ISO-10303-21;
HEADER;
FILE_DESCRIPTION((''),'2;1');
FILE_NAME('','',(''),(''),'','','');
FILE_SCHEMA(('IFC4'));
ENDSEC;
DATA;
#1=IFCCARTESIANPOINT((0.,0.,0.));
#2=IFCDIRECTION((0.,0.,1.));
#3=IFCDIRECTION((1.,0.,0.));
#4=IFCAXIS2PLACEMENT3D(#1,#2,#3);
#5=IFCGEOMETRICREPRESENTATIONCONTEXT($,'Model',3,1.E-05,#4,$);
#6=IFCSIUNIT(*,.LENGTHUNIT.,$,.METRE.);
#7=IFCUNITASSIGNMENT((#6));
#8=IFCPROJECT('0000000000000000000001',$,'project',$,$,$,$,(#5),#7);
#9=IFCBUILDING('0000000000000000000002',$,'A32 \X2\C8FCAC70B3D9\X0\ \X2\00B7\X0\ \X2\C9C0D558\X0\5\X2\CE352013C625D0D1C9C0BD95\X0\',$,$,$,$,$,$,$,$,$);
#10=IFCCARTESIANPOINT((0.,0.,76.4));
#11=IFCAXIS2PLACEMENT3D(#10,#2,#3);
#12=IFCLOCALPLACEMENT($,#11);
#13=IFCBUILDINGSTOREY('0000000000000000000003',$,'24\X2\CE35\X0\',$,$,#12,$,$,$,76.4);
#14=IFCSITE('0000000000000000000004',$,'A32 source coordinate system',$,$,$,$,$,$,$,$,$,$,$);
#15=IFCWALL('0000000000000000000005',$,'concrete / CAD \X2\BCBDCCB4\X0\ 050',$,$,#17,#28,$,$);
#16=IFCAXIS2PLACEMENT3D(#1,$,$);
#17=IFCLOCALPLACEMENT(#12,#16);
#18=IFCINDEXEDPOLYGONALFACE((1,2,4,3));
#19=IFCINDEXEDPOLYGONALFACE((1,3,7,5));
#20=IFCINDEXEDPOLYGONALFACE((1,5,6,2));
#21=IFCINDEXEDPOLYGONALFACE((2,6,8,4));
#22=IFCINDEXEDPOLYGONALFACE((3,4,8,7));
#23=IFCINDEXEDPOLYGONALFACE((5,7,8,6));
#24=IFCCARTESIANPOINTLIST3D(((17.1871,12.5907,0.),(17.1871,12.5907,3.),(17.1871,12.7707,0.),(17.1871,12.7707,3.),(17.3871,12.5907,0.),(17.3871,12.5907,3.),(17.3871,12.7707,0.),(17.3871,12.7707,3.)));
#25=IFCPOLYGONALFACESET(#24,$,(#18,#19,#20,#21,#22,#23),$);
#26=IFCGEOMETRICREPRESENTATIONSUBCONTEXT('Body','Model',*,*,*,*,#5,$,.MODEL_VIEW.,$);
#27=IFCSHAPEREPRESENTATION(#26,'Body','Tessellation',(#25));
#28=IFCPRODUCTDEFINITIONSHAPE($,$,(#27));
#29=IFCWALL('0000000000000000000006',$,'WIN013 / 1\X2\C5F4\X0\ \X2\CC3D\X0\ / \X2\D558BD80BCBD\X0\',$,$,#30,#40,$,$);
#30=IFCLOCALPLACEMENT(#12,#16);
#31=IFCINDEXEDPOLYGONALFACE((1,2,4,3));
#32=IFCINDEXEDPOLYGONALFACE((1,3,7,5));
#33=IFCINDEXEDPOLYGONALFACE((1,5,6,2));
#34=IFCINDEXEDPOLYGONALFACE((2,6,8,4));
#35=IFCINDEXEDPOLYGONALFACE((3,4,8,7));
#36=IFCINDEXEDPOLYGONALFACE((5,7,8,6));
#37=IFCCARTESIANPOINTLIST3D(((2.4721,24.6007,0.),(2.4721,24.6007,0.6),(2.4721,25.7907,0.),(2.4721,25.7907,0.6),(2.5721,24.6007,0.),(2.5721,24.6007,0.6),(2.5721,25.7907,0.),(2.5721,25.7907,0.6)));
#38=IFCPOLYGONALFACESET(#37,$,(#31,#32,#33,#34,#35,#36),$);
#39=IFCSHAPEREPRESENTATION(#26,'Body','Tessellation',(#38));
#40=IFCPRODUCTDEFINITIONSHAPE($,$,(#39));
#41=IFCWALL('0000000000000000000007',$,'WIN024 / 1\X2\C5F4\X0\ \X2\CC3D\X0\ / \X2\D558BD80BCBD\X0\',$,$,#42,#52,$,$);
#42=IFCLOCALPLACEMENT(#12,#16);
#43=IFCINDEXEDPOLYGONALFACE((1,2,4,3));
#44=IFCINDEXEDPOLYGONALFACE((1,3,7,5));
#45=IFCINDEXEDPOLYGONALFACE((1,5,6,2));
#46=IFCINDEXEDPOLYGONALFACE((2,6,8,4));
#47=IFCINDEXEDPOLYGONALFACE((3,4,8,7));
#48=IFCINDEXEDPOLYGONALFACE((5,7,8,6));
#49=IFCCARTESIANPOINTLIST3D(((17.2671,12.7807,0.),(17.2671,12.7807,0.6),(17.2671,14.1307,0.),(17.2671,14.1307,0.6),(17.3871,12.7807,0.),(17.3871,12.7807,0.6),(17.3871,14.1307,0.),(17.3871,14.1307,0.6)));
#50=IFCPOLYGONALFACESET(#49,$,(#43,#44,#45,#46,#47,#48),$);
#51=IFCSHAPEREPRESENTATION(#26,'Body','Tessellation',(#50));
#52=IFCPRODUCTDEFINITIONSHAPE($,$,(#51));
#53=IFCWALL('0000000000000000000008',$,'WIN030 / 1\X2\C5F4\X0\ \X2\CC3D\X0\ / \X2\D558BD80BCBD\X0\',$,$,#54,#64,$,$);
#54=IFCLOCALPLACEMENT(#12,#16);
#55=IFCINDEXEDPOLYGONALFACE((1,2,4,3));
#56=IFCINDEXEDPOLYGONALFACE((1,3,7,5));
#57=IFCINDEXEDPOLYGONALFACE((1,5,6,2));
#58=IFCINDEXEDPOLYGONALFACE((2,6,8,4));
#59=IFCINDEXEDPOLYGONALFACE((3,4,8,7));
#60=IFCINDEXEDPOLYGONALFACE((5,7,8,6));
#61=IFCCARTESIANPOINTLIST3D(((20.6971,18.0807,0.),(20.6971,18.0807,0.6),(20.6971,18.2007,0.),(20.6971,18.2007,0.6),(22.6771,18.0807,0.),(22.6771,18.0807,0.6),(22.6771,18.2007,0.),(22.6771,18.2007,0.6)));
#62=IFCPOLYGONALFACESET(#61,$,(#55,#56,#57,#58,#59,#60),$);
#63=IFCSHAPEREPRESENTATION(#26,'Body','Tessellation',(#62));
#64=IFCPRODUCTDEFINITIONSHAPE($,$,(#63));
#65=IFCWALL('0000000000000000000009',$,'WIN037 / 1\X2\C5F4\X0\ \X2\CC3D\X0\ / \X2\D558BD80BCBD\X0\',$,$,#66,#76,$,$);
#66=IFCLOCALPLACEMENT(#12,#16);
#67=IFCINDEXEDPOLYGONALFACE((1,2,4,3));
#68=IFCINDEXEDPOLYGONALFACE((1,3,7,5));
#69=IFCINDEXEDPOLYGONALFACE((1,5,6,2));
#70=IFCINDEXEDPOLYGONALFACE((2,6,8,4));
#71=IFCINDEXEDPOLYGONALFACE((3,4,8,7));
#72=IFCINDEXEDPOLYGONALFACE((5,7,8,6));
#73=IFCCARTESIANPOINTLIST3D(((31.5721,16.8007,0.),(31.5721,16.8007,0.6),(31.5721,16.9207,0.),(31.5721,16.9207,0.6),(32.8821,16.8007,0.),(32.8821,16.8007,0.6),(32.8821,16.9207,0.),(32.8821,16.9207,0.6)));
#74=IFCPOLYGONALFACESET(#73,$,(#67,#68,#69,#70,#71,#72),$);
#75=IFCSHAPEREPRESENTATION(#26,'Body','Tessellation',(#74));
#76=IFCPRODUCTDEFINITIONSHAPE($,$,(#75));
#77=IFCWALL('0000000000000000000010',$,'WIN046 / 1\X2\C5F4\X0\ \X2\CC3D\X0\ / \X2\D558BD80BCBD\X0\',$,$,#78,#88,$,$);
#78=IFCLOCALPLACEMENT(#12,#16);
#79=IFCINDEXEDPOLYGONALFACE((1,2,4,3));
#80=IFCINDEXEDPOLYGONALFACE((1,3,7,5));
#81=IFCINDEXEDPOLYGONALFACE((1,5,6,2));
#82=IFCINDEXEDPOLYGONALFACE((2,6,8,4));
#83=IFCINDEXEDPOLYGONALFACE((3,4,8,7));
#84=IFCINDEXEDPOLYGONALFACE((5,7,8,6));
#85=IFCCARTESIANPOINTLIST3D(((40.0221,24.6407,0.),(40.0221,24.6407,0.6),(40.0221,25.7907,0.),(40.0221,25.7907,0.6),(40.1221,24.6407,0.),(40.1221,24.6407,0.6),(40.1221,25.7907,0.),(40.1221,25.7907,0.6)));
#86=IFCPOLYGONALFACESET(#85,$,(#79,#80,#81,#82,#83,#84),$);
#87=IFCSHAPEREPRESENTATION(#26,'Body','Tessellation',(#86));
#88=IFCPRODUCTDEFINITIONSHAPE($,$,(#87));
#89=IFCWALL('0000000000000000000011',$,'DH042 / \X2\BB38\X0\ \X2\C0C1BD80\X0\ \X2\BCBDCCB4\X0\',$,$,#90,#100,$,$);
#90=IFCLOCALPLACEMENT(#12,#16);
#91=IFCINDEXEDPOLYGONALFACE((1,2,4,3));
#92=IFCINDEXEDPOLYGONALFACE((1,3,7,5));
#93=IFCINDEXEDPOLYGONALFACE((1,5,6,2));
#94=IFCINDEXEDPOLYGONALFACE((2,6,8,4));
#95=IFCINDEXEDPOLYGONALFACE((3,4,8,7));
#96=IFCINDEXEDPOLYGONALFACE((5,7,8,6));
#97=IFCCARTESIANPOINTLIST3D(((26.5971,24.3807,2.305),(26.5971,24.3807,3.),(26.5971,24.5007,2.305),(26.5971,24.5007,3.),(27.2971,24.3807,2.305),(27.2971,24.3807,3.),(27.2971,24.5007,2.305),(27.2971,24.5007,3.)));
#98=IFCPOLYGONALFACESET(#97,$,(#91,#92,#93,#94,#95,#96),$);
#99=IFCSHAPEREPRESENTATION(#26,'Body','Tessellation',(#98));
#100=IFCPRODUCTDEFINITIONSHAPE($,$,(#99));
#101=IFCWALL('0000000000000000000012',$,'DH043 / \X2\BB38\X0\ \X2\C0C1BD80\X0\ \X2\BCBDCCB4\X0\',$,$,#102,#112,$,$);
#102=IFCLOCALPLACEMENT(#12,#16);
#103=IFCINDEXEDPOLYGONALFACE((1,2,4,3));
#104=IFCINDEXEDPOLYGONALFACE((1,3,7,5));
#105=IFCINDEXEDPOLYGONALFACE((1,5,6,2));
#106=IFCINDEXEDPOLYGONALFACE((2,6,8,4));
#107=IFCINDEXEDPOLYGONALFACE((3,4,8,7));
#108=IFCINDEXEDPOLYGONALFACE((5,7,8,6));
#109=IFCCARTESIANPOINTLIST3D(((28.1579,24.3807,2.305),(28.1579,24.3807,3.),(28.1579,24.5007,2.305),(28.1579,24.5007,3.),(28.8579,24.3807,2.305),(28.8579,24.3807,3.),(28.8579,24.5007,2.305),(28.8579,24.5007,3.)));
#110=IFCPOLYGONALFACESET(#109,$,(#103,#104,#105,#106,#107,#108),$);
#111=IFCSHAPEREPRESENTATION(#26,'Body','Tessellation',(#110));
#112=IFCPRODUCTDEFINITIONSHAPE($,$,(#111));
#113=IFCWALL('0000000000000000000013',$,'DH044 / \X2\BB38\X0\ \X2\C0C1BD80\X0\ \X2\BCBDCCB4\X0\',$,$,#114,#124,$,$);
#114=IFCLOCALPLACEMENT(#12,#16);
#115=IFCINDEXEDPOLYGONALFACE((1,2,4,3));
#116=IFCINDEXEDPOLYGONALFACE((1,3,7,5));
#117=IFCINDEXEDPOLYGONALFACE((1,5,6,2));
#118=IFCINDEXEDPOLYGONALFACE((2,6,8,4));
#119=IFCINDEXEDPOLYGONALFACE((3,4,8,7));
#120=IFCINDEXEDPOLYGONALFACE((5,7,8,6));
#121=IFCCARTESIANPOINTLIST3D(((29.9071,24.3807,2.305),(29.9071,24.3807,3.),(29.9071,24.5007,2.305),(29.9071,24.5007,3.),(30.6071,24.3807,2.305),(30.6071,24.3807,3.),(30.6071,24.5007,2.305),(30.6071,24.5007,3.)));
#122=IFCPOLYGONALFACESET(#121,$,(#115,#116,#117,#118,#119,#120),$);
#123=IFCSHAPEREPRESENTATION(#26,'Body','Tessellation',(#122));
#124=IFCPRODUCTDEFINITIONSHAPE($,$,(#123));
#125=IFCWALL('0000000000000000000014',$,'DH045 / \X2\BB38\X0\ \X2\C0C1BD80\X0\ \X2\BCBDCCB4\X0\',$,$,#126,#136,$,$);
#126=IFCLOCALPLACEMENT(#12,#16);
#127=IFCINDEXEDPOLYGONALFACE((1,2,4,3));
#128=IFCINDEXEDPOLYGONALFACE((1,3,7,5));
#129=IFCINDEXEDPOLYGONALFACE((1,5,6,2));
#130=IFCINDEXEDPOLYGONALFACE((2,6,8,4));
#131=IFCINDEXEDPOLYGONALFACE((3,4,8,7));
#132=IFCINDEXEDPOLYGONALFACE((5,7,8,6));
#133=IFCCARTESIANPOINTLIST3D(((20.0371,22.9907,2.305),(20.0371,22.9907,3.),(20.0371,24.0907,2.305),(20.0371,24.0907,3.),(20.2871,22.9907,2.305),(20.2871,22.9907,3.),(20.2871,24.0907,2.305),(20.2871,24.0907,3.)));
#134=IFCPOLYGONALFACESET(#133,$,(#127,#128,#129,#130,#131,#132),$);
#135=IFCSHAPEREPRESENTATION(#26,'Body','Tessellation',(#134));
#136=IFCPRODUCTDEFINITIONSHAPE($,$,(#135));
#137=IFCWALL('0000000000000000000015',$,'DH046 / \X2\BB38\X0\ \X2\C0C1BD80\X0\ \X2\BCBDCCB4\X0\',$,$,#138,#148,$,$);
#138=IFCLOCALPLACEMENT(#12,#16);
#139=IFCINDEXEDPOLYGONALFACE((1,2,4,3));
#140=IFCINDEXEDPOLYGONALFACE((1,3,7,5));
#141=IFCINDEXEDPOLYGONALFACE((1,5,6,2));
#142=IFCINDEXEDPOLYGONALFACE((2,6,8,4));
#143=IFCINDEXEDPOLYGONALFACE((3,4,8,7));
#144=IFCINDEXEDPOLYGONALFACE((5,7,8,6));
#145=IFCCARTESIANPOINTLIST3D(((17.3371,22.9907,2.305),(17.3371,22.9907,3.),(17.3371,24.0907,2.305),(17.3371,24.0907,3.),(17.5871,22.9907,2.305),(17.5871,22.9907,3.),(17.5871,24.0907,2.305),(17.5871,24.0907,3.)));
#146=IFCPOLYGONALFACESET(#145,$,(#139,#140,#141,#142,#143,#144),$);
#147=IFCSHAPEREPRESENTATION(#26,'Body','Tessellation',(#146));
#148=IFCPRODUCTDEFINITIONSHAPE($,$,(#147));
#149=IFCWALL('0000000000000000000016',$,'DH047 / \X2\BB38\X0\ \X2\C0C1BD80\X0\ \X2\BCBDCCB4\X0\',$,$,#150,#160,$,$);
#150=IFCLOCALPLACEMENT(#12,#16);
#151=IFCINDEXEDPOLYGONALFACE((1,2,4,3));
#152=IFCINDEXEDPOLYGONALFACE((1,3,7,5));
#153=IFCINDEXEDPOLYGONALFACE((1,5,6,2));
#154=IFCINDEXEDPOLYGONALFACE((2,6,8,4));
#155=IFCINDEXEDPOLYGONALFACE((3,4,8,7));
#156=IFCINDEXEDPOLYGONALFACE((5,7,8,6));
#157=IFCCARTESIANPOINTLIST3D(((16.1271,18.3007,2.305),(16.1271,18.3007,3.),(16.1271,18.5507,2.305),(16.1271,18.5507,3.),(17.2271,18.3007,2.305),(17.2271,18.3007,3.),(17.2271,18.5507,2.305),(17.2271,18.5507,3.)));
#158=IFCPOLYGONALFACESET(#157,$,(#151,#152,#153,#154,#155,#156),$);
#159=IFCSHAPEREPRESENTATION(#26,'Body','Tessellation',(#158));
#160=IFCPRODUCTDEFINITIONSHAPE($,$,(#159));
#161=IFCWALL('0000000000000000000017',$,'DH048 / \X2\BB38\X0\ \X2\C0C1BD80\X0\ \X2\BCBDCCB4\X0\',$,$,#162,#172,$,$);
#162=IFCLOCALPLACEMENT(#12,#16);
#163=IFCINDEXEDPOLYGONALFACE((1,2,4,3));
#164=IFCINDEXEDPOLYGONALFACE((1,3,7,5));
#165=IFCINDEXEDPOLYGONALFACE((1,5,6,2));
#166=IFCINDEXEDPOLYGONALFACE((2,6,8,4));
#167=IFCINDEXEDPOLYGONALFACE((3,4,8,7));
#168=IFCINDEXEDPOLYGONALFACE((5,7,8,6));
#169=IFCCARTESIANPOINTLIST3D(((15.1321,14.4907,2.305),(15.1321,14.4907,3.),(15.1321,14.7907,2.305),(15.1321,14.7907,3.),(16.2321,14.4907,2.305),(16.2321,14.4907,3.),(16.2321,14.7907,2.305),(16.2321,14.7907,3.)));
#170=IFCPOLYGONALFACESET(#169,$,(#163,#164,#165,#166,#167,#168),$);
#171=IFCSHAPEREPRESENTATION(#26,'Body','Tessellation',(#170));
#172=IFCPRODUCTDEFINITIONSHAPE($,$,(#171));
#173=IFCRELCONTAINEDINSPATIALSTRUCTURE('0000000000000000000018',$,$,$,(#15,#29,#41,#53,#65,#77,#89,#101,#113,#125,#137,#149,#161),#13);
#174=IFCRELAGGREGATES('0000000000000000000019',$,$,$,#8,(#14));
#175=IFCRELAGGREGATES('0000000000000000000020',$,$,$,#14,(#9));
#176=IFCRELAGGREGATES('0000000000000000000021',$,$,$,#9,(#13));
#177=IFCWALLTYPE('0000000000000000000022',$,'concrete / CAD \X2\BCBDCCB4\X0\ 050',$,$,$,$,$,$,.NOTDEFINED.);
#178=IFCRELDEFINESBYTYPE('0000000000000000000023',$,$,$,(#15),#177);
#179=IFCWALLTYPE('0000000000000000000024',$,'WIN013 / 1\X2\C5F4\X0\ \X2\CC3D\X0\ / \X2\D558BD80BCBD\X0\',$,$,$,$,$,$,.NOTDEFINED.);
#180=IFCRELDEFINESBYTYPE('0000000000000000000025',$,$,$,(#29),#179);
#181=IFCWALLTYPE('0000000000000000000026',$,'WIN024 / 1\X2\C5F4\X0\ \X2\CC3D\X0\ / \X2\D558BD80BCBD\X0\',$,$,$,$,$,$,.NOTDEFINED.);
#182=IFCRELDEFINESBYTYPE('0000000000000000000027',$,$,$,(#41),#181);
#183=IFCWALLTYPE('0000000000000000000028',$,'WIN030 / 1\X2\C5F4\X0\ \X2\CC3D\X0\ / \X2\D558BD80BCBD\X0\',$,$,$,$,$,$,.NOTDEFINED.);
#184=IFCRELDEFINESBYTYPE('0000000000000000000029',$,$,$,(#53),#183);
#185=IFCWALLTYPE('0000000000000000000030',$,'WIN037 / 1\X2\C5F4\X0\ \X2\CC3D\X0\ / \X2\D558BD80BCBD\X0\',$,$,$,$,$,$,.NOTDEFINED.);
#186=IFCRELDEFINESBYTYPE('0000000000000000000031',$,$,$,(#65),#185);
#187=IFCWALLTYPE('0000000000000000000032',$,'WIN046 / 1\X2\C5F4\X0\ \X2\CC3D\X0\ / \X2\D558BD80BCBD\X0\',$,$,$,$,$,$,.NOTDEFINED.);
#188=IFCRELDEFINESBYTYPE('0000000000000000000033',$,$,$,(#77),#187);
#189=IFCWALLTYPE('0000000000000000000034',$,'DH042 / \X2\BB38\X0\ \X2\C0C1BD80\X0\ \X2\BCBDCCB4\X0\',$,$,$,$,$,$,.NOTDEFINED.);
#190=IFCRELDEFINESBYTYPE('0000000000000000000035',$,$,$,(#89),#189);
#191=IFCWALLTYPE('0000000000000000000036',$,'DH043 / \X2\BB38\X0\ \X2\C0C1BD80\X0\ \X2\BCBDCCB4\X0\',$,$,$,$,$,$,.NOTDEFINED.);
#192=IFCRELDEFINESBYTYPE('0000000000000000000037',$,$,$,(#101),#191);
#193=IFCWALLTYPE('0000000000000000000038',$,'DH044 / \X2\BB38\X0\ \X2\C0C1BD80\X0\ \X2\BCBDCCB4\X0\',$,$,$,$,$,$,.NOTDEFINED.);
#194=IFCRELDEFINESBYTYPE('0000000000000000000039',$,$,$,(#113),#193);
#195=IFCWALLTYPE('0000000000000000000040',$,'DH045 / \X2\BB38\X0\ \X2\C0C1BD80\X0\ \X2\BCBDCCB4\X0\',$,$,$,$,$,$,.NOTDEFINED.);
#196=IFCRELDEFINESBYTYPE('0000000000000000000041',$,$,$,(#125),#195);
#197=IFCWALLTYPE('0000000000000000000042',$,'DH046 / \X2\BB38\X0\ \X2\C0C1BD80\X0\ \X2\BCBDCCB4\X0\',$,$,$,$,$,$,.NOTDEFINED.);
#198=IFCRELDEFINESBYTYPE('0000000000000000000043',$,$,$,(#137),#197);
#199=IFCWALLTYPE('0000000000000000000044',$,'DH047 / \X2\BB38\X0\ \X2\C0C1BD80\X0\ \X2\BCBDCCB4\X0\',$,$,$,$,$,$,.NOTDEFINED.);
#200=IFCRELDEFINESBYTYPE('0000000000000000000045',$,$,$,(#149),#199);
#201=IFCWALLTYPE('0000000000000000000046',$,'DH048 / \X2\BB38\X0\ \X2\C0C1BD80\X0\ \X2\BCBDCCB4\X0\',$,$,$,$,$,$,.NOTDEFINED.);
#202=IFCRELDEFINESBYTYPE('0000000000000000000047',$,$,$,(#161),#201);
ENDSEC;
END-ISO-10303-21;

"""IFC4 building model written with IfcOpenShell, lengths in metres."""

from ifc_helpers import new_model, si_unit, frame, origin, origin_with_axes, place, context, subcontext, project, spatial, polyline, outline, extrude, source, transform, mapped, type_object, type_shapes, element, save


model = new_model("IFC4")

# Units and contexts
model_context = context("Model", 3, precision=1e-05, world=origin_with_axes())
body_context = subcontext(model_context, "Body", "Model", "MODEL_VIEW")
ifc_project = project(units=[si_unit("LENGTHUNIT", "METRE")], contexts=[model_context])

# Site, building, storey
site = spatial("IfcSite", under=ifc_project, Name="A32 source coordinate system")
building = spatial("IfcBuilding", under=site, Name="A32 주거동 · 지하5층–옥탑지붕")
storey_placement = place(None, frame((0.0, 0.0, 76.4), z_axis=(0.0, 0.0, 1.0), x_axis=(1.0, 0.0, 0.0)))
storey = spatial("IfcBuildingStorey", under=building, at=storey_placement, Name="24층", Elevation=76.4)

# Walls
wall_type_1 = type_object("IfcWallType", Name="concrete / CAD 벽체 050", PredefinedType="NOTDEFINED")
shared_shape_1 = source(origin(), body_context, "Body", "SweptSolid", [
    extrude(outline(polyline([(17.1871, 12.5907), (17.1871, 12.7707), (17.3871, 12.7707), (17.3871, 12.5907), (17.1871, 12.5907)])), origin(), (0.0, 0.0, 1.0), 3.0),
])
type_shapes(wall_type_1, [shared_shape_1])
wall_1_placement = place(storey_placement, origin_with_axes())
element("IfcWall", 1, at=wall_1_placement, inside=storey, type_object=wall_type_1, Name="concrete / CAD 벽체 050", context=body_context, shape_type="MappedRepresentation", body=[
    mapped(shared_shape_1, transform((0.0, 0.0, 0.0), scale=1.0)),
])
wall_type_2 = type_object("IfcWallType", Name="WIN013 / 1열 창 / 하부벽", PredefinedType="NOTDEFINED")
shared_shape_2 = source(origin(), body_context, "Body", "SweptSolid", [
    extrude(outline(polyline([(2.5721, 25.7907), (2.5721, 24.6007), (2.4721, 24.6007), (2.4721, 25.7907), (2.5721, 25.7907)])), origin(), (0.0, 0.0, 1.0), 0.6),
])
type_shapes(wall_type_2, [shared_shape_2])
wall_2_placement = place(storey_placement, origin_with_axes())
element("IfcWall", 2, at=wall_2_placement, inside=storey, type_object=wall_type_2, Name="WIN013 / 1열 창 / 하부벽", context=body_context, shape_type="MappedRepresentation", body=[
    mapped(shared_shape_2, transform((0.0, 0.0, 0.0), scale=1.0)),
])
wall_type_3 = type_object("IfcWallType", Name="WIN024 / 1열 창 / 하부벽", PredefinedType="NOTDEFINED")
shared_shape_3 = source(origin(), body_context, "Body", "SweptSolid", [
    extrude(outline(polyline([(17.3871, 14.1307), (17.3871, 12.7807), (17.2671, 12.7807), (17.2671, 14.1307), (17.3871, 14.1307)])), origin(), (0.0, 0.0, 1.0), 0.6),
])
type_shapes(wall_type_3, [shared_shape_3])
wall_3_placement = place(storey_placement, origin_with_axes())
element("IfcWall", 3, at=wall_3_placement, inside=storey, type_object=wall_type_3, Name="WIN024 / 1열 창 / 하부벽", context=body_context, shape_type="MappedRepresentation", body=[
    mapped(shared_shape_3, transform((0.0, 0.0, 0.0), scale=1.0)),
])
wall_type_4 = type_object("IfcWallType", Name="WIN030 / 1열 창 / 하부벽", PredefinedType="NOTDEFINED")
shared_shape_4 = source(origin(), body_context, "Body", "SweptSolid", [
    extrude(outline(polyline([(22.6771, 18.2007), (22.6771, 18.0807), (20.6971, 18.0807), (20.6971, 18.2007), (22.6771, 18.2007)])), origin(), (0.0, 0.0, 1.0), 0.6),
])
type_shapes(wall_type_4, [shared_shape_4])
wall_4_placement = place(storey_placement, origin_with_axes())
element("IfcWall", 4, at=wall_4_placement, inside=storey, type_object=wall_type_4, Name="WIN030 / 1열 창 / 하부벽", context=body_context, shape_type="MappedRepresentation", body=[
    mapped(shared_shape_4, transform((0.0, 0.0, 0.0), scale=1.0)),
])
wall_type_5 = type_object("IfcWallType", Name="WIN037 / 1열 창 / 하부벽", PredefinedType="NOTDEFINED")
shared_shape_5 = source(origin(), body_context, "Body", "SweptSolid", [
    extrude(outline(polyline([(32.8821, 16.9207), (32.8821, 16.8007), (31.5721, 16.8007), (31.5721, 16.9207), (32.8821, 16.9207)])), origin(), (0.0, 0.0, 1.0), 0.6),
])
type_shapes(wall_type_5, [shared_shape_5])
wall_5_placement = place(storey_placement, origin_with_axes())
element("IfcWall", 5, at=wall_5_placement, inside=storey, type_object=wall_type_5, Name="WIN037 / 1열 창 / 하부벽", context=body_context, shape_type="MappedRepresentation", body=[
    mapped(shared_shape_5, transform((0.0, 0.0, 0.0), scale=1.0)),
])
wall_type_6 = type_object("IfcWallType", Name="WIN046 / 1열 창 / 하부벽", PredefinedType="NOTDEFINED")
shared_shape_6 = source(origin(), body_context, "Body", "SweptSolid", [
    extrude(outline(polyline([(40.1221, 25.7907), (40.1221, 24.6407), (40.0221, 24.6407), (40.0221, 25.7907), (40.1221, 25.7907)])), origin(), (0.0, 0.0, 1.0), 0.6),
])
type_shapes(wall_type_6, [shared_shape_6])
wall_6_placement = place(storey_placement, origin_with_axes())
element("IfcWall", 6, at=wall_6_placement, inside=storey, type_object=wall_type_6, Name="WIN046 / 1열 창 / 하부벽", context=body_context, shape_type="MappedRepresentation", body=[
    mapped(shared_shape_6, transform((0.0, 0.0, 0.0), scale=1.0)),
])
wall_type_7 = type_object("IfcWallType", Name="DH042 / 문 상부 벽체", PredefinedType="NOTDEFINED")
shared_shape_7 = source(origin(), body_context, "Body", "SweptSolid", [
    extrude(outline(polyline([(27.2971, 24.3807), (26.5971, 24.3807), (26.5971, 24.5007), (27.2971, 24.5007), (27.2971, 24.3807)])), frame((0.0, 0.0, 2.305)), (0.0, 0.0, 1.0), 0.695),
])
type_shapes(wall_type_7, [shared_shape_7])
wall_7_placement = place(storey_placement, origin_with_axes())
element("IfcWall", 7, at=wall_7_placement, inside=storey, type_object=wall_type_7, Name="DH042 / 문 상부 벽체", context=body_context, shape_type="MappedRepresentation", body=[
    mapped(shared_shape_7, transform((0.0, 0.0, 0.0), scale=1.0)),
])
wall_type_8 = type_object("IfcWallType", Name="DH043 / 문 상부 벽체", PredefinedType="NOTDEFINED")
shared_shape_8 = source(origin(), body_context, "Body", "SweptSolid", [
    extrude(outline(polyline([(28.8579, 24.3807), (28.1579, 24.3807), (28.1579, 24.5007), (28.8579, 24.5007), (28.8579, 24.3807)])), frame((0.0, 0.0, 2.305)), (0.0, 0.0, 1.0), 0.695),
])
type_shapes(wall_type_8, [shared_shape_8])
wall_8_placement = place(storey_placement, origin_with_axes())
element("IfcWall", 8, at=wall_8_placement, inside=storey, type_object=wall_type_8, Name="DH043 / 문 상부 벽체", context=body_context, shape_type="MappedRepresentation", body=[
    mapped(shared_shape_8, transform((0.0, 0.0, 0.0), scale=1.0)),
])
wall_type_9 = type_object("IfcWallType", Name="DH044 / 문 상부 벽체", PredefinedType="NOTDEFINED")
shared_shape_9 = source(origin(), body_context, "Body", "SweptSolid", [
    extrude(outline(polyline([(30.6071, 24.3807), (29.9071, 24.3807), (29.9071, 24.5007), (30.6071, 24.5007), (30.6071, 24.3807)])), frame((0.0, 0.0, 2.305)), (0.0, 0.0, 1.0), 0.695),
])
type_shapes(wall_type_9, [shared_shape_9])
wall_9_placement = place(storey_placement, origin_with_axes())
element("IfcWall", 9, at=wall_9_placement, inside=storey, type_object=wall_type_9, Name="DH044 / 문 상부 벽체", context=body_context, shape_type="MappedRepresentation", body=[
    mapped(shared_shape_9, transform((0.0, 0.0, 0.0), scale=1.0)),
])
wall_type_10 = type_object("IfcWallType", Name="DH045 / 문 상부 벽체", PredefinedType="NOTDEFINED")
shared_shape_10 = source(origin(), body_context, "Body", "SweptSolid", [
    extrude(outline(polyline([(20.2871, 22.9907), (20.0371, 22.9907), (20.0371, 24.0907), (20.2871, 24.0907), (20.2871, 22.9907)])), frame((0.0, 0.0, 2.305)), (0.0, 0.0, 1.0), 0.695),
])
type_shapes(wall_type_10, [shared_shape_10])
wall_10_placement = place(storey_placement, origin_with_axes())
element("IfcWall", 10, at=wall_10_placement, inside=storey, type_object=wall_type_10, Name="DH045 / 문 상부 벽체", context=body_context, shape_type="MappedRepresentation", body=[
    mapped(shared_shape_10, transform((0.0, 0.0, 0.0), scale=1.0)),
])
wall_type_11 = type_object("IfcWallType", Name="DH046 / 문 상부 벽체", PredefinedType="NOTDEFINED")
shared_shape_11 = source(origin(), body_context, "Body", "SweptSolid", [
    extrude(outline(polyline([(17.5871, 22.9907), (17.3371, 22.9907), (17.3371, 24.0907), (17.5871, 24.0907), (17.5871, 22.9907)])), frame((0.0, 0.0, 2.305)), (0.0, 0.0, 1.0), 0.695),
])
type_shapes(wall_type_11, [shared_shape_11])
wall_11_placement = place(storey_placement, origin_with_axes())
element("IfcWall", 11, at=wall_11_placement, inside=storey, type_object=wall_type_11, Name="DH046 / 문 상부 벽체", context=body_context, shape_type="MappedRepresentation", body=[
    mapped(shared_shape_11, transform((0.0, 0.0, 0.0), scale=1.0)),
])
wall_type_12 = type_object("IfcWallType", Name="DH047 / 문 상부 벽체", PredefinedType="NOTDEFINED")
shared_shape_12 = source(origin(), body_context, "Body", "SweptSolid", [
    extrude(outline(polyline([(17.2271, 18.3007), (16.1271, 18.3007), (16.1271, 18.5507), (17.2271, 18.5507), (17.2271, 18.3007)])), frame((0.0, 0.0, 2.305)), (0.0, 0.0, 1.0), 0.695),
])
type_shapes(wall_type_12, [shared_shape_12])
wall_12_placement = place(storey_placement, origin_with_axes())
element("IfcWall", 12, at=wall_12_placement, inside=storey, type_object=wall_type_12, Name="DH047 / 문 상부 벽체", context=body_context, shape_type="MappedRepresentation", body=[
    mapped(shared_shape_12, transform((0.0, 0.0, 0.0), scale=1.0)),
])
wall_type_13 = type_object("IfcWallType", Name="DH048 / 문 상부 벽체", PredefinedType="NOTDEFINED")
shared_shape_13 = source(origin(), body_context, "Body", "SweptSolid", [
    extrude(outline(polyline([(15.1321, 14.7907), (16.2321, 14.7907), (16.2321, 14.4907), (15.1321, 14.4907), (15.1321, 14.7907)])), frame((0.0, 0.0, 2.305)), (0.0, 0.0, 1.0), 0.695),
])
type_shapes(wall_type_13, [shared_shape_13])
wall_13_placement = place(storey_placement, origin_with_axes())
element("IfcWall", 13, at=wall_13_placement, inside=storey, type_object=wall_type_13, Name="DH048 / 문 상부 벽체", context=body_context, shape_type="MappedRepresentation", body=[
    mapped(shared_shape_13, transform((0.0, 0.0, 0.0), scale=1.0)),
])

save(model, "model.ifc")
